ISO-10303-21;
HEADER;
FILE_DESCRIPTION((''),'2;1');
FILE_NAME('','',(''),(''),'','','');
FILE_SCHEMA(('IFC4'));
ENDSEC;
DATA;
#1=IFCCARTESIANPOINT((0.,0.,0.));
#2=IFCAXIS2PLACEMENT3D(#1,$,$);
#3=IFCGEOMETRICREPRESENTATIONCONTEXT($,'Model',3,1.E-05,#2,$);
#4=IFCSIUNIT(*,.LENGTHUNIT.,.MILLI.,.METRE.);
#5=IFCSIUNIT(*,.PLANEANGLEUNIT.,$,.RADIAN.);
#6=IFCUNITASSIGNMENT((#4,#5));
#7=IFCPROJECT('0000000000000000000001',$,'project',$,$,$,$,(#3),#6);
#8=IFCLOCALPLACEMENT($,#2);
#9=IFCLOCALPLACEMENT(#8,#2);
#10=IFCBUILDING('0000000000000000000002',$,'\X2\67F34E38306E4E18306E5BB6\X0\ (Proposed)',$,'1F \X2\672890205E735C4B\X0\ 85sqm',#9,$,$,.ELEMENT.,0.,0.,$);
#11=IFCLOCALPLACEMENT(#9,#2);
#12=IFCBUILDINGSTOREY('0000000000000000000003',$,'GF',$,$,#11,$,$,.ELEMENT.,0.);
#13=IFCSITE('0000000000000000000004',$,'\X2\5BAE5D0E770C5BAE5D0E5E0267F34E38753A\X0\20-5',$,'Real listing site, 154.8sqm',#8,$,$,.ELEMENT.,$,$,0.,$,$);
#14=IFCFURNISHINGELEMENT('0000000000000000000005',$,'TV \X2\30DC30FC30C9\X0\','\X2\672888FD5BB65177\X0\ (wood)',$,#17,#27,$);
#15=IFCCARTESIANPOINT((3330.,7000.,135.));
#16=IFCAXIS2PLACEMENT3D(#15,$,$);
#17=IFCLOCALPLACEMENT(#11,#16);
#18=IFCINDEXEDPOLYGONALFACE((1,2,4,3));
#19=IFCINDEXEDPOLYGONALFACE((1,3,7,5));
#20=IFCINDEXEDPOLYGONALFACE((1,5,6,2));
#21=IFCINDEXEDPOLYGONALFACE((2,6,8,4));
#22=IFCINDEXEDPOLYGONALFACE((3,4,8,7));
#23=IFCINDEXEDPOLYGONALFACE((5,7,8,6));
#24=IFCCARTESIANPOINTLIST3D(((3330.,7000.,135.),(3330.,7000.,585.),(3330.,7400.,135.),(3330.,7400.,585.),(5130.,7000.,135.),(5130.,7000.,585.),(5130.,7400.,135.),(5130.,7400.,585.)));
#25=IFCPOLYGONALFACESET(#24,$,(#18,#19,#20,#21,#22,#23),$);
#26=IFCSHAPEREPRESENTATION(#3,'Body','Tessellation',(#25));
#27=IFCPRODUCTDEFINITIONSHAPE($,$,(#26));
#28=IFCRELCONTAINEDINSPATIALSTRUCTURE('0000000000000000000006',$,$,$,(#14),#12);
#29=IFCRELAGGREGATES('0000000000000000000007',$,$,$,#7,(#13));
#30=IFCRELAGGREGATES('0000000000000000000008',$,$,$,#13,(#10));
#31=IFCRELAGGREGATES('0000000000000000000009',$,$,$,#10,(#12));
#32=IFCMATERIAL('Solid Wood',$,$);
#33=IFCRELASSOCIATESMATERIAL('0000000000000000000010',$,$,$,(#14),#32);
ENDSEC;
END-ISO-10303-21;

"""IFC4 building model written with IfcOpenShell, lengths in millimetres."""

from ifc_helpers import new_model, si_unit, frame, frame_2d, origin, place, context, project, spatial, rectangle, extrude, material, element, save


model = new_model("IFC4")

# Units and contexts
model_context = context("Model", 3, precision=1e-05, world=origin())
ifc_project = project(units=[si_unit("LENGTHUNIT", "METRE", prefix="MILLI"), si_unit("PLANEANGLEUNIT", "RADIAN")], contexts=[model_context])

# Site, building, storey
site_placement = place(None, origin())
site = spatial("IfcSite", under=ifc_project, at=site_placement, Name="宮崎県宮崎市柳丸町20-5", ObjectType="Real listing site, 154.8sqm", CompositionType="ELEMENT", RefElevation=0.0)
building_placement = place(site_placement, origin())
building = spatial("IfcBuilding", under=site, at=building_placement, Name="柳丸の丘の家 (Proposed)", ObjectType="1F 木造平屋 85sqm", CompositionType="ELEMENT", ElevationOfRefHeight=0.0, ElevationOfTerrain=0.0)
storey_placement = place(building_placement, origin())
storey = spatial("IfcBuildingStorey", under=building, at=storey_placement, Name="GF", CompositionType="ELEMENT", Elevation=0.0)

# Shared definitions
ifc_material_1 = material(Name="Solid Wood")

# Furnishing element
furnishing_1_placement = place(storey_placement, frame((3330.0, 7000.0, 135.0)))
element("IfcFurnishingElement", 1, at=furnishing_1_placement, inside=storey, material=ifc_material_1, Name="TV ボード", Description="木製家具 (wood)", context=model_context, shape_type="SweptSolid", body=[
    extrude(rectangle(XDim=1800.0, YDim=400.0, at=frame_2d((900.0, 200.0))), frame((3330.0, 7000.0, 135.0)), (0.0, 0.0, 1.0), 450.0),
])

save(model, "model.ifc")
